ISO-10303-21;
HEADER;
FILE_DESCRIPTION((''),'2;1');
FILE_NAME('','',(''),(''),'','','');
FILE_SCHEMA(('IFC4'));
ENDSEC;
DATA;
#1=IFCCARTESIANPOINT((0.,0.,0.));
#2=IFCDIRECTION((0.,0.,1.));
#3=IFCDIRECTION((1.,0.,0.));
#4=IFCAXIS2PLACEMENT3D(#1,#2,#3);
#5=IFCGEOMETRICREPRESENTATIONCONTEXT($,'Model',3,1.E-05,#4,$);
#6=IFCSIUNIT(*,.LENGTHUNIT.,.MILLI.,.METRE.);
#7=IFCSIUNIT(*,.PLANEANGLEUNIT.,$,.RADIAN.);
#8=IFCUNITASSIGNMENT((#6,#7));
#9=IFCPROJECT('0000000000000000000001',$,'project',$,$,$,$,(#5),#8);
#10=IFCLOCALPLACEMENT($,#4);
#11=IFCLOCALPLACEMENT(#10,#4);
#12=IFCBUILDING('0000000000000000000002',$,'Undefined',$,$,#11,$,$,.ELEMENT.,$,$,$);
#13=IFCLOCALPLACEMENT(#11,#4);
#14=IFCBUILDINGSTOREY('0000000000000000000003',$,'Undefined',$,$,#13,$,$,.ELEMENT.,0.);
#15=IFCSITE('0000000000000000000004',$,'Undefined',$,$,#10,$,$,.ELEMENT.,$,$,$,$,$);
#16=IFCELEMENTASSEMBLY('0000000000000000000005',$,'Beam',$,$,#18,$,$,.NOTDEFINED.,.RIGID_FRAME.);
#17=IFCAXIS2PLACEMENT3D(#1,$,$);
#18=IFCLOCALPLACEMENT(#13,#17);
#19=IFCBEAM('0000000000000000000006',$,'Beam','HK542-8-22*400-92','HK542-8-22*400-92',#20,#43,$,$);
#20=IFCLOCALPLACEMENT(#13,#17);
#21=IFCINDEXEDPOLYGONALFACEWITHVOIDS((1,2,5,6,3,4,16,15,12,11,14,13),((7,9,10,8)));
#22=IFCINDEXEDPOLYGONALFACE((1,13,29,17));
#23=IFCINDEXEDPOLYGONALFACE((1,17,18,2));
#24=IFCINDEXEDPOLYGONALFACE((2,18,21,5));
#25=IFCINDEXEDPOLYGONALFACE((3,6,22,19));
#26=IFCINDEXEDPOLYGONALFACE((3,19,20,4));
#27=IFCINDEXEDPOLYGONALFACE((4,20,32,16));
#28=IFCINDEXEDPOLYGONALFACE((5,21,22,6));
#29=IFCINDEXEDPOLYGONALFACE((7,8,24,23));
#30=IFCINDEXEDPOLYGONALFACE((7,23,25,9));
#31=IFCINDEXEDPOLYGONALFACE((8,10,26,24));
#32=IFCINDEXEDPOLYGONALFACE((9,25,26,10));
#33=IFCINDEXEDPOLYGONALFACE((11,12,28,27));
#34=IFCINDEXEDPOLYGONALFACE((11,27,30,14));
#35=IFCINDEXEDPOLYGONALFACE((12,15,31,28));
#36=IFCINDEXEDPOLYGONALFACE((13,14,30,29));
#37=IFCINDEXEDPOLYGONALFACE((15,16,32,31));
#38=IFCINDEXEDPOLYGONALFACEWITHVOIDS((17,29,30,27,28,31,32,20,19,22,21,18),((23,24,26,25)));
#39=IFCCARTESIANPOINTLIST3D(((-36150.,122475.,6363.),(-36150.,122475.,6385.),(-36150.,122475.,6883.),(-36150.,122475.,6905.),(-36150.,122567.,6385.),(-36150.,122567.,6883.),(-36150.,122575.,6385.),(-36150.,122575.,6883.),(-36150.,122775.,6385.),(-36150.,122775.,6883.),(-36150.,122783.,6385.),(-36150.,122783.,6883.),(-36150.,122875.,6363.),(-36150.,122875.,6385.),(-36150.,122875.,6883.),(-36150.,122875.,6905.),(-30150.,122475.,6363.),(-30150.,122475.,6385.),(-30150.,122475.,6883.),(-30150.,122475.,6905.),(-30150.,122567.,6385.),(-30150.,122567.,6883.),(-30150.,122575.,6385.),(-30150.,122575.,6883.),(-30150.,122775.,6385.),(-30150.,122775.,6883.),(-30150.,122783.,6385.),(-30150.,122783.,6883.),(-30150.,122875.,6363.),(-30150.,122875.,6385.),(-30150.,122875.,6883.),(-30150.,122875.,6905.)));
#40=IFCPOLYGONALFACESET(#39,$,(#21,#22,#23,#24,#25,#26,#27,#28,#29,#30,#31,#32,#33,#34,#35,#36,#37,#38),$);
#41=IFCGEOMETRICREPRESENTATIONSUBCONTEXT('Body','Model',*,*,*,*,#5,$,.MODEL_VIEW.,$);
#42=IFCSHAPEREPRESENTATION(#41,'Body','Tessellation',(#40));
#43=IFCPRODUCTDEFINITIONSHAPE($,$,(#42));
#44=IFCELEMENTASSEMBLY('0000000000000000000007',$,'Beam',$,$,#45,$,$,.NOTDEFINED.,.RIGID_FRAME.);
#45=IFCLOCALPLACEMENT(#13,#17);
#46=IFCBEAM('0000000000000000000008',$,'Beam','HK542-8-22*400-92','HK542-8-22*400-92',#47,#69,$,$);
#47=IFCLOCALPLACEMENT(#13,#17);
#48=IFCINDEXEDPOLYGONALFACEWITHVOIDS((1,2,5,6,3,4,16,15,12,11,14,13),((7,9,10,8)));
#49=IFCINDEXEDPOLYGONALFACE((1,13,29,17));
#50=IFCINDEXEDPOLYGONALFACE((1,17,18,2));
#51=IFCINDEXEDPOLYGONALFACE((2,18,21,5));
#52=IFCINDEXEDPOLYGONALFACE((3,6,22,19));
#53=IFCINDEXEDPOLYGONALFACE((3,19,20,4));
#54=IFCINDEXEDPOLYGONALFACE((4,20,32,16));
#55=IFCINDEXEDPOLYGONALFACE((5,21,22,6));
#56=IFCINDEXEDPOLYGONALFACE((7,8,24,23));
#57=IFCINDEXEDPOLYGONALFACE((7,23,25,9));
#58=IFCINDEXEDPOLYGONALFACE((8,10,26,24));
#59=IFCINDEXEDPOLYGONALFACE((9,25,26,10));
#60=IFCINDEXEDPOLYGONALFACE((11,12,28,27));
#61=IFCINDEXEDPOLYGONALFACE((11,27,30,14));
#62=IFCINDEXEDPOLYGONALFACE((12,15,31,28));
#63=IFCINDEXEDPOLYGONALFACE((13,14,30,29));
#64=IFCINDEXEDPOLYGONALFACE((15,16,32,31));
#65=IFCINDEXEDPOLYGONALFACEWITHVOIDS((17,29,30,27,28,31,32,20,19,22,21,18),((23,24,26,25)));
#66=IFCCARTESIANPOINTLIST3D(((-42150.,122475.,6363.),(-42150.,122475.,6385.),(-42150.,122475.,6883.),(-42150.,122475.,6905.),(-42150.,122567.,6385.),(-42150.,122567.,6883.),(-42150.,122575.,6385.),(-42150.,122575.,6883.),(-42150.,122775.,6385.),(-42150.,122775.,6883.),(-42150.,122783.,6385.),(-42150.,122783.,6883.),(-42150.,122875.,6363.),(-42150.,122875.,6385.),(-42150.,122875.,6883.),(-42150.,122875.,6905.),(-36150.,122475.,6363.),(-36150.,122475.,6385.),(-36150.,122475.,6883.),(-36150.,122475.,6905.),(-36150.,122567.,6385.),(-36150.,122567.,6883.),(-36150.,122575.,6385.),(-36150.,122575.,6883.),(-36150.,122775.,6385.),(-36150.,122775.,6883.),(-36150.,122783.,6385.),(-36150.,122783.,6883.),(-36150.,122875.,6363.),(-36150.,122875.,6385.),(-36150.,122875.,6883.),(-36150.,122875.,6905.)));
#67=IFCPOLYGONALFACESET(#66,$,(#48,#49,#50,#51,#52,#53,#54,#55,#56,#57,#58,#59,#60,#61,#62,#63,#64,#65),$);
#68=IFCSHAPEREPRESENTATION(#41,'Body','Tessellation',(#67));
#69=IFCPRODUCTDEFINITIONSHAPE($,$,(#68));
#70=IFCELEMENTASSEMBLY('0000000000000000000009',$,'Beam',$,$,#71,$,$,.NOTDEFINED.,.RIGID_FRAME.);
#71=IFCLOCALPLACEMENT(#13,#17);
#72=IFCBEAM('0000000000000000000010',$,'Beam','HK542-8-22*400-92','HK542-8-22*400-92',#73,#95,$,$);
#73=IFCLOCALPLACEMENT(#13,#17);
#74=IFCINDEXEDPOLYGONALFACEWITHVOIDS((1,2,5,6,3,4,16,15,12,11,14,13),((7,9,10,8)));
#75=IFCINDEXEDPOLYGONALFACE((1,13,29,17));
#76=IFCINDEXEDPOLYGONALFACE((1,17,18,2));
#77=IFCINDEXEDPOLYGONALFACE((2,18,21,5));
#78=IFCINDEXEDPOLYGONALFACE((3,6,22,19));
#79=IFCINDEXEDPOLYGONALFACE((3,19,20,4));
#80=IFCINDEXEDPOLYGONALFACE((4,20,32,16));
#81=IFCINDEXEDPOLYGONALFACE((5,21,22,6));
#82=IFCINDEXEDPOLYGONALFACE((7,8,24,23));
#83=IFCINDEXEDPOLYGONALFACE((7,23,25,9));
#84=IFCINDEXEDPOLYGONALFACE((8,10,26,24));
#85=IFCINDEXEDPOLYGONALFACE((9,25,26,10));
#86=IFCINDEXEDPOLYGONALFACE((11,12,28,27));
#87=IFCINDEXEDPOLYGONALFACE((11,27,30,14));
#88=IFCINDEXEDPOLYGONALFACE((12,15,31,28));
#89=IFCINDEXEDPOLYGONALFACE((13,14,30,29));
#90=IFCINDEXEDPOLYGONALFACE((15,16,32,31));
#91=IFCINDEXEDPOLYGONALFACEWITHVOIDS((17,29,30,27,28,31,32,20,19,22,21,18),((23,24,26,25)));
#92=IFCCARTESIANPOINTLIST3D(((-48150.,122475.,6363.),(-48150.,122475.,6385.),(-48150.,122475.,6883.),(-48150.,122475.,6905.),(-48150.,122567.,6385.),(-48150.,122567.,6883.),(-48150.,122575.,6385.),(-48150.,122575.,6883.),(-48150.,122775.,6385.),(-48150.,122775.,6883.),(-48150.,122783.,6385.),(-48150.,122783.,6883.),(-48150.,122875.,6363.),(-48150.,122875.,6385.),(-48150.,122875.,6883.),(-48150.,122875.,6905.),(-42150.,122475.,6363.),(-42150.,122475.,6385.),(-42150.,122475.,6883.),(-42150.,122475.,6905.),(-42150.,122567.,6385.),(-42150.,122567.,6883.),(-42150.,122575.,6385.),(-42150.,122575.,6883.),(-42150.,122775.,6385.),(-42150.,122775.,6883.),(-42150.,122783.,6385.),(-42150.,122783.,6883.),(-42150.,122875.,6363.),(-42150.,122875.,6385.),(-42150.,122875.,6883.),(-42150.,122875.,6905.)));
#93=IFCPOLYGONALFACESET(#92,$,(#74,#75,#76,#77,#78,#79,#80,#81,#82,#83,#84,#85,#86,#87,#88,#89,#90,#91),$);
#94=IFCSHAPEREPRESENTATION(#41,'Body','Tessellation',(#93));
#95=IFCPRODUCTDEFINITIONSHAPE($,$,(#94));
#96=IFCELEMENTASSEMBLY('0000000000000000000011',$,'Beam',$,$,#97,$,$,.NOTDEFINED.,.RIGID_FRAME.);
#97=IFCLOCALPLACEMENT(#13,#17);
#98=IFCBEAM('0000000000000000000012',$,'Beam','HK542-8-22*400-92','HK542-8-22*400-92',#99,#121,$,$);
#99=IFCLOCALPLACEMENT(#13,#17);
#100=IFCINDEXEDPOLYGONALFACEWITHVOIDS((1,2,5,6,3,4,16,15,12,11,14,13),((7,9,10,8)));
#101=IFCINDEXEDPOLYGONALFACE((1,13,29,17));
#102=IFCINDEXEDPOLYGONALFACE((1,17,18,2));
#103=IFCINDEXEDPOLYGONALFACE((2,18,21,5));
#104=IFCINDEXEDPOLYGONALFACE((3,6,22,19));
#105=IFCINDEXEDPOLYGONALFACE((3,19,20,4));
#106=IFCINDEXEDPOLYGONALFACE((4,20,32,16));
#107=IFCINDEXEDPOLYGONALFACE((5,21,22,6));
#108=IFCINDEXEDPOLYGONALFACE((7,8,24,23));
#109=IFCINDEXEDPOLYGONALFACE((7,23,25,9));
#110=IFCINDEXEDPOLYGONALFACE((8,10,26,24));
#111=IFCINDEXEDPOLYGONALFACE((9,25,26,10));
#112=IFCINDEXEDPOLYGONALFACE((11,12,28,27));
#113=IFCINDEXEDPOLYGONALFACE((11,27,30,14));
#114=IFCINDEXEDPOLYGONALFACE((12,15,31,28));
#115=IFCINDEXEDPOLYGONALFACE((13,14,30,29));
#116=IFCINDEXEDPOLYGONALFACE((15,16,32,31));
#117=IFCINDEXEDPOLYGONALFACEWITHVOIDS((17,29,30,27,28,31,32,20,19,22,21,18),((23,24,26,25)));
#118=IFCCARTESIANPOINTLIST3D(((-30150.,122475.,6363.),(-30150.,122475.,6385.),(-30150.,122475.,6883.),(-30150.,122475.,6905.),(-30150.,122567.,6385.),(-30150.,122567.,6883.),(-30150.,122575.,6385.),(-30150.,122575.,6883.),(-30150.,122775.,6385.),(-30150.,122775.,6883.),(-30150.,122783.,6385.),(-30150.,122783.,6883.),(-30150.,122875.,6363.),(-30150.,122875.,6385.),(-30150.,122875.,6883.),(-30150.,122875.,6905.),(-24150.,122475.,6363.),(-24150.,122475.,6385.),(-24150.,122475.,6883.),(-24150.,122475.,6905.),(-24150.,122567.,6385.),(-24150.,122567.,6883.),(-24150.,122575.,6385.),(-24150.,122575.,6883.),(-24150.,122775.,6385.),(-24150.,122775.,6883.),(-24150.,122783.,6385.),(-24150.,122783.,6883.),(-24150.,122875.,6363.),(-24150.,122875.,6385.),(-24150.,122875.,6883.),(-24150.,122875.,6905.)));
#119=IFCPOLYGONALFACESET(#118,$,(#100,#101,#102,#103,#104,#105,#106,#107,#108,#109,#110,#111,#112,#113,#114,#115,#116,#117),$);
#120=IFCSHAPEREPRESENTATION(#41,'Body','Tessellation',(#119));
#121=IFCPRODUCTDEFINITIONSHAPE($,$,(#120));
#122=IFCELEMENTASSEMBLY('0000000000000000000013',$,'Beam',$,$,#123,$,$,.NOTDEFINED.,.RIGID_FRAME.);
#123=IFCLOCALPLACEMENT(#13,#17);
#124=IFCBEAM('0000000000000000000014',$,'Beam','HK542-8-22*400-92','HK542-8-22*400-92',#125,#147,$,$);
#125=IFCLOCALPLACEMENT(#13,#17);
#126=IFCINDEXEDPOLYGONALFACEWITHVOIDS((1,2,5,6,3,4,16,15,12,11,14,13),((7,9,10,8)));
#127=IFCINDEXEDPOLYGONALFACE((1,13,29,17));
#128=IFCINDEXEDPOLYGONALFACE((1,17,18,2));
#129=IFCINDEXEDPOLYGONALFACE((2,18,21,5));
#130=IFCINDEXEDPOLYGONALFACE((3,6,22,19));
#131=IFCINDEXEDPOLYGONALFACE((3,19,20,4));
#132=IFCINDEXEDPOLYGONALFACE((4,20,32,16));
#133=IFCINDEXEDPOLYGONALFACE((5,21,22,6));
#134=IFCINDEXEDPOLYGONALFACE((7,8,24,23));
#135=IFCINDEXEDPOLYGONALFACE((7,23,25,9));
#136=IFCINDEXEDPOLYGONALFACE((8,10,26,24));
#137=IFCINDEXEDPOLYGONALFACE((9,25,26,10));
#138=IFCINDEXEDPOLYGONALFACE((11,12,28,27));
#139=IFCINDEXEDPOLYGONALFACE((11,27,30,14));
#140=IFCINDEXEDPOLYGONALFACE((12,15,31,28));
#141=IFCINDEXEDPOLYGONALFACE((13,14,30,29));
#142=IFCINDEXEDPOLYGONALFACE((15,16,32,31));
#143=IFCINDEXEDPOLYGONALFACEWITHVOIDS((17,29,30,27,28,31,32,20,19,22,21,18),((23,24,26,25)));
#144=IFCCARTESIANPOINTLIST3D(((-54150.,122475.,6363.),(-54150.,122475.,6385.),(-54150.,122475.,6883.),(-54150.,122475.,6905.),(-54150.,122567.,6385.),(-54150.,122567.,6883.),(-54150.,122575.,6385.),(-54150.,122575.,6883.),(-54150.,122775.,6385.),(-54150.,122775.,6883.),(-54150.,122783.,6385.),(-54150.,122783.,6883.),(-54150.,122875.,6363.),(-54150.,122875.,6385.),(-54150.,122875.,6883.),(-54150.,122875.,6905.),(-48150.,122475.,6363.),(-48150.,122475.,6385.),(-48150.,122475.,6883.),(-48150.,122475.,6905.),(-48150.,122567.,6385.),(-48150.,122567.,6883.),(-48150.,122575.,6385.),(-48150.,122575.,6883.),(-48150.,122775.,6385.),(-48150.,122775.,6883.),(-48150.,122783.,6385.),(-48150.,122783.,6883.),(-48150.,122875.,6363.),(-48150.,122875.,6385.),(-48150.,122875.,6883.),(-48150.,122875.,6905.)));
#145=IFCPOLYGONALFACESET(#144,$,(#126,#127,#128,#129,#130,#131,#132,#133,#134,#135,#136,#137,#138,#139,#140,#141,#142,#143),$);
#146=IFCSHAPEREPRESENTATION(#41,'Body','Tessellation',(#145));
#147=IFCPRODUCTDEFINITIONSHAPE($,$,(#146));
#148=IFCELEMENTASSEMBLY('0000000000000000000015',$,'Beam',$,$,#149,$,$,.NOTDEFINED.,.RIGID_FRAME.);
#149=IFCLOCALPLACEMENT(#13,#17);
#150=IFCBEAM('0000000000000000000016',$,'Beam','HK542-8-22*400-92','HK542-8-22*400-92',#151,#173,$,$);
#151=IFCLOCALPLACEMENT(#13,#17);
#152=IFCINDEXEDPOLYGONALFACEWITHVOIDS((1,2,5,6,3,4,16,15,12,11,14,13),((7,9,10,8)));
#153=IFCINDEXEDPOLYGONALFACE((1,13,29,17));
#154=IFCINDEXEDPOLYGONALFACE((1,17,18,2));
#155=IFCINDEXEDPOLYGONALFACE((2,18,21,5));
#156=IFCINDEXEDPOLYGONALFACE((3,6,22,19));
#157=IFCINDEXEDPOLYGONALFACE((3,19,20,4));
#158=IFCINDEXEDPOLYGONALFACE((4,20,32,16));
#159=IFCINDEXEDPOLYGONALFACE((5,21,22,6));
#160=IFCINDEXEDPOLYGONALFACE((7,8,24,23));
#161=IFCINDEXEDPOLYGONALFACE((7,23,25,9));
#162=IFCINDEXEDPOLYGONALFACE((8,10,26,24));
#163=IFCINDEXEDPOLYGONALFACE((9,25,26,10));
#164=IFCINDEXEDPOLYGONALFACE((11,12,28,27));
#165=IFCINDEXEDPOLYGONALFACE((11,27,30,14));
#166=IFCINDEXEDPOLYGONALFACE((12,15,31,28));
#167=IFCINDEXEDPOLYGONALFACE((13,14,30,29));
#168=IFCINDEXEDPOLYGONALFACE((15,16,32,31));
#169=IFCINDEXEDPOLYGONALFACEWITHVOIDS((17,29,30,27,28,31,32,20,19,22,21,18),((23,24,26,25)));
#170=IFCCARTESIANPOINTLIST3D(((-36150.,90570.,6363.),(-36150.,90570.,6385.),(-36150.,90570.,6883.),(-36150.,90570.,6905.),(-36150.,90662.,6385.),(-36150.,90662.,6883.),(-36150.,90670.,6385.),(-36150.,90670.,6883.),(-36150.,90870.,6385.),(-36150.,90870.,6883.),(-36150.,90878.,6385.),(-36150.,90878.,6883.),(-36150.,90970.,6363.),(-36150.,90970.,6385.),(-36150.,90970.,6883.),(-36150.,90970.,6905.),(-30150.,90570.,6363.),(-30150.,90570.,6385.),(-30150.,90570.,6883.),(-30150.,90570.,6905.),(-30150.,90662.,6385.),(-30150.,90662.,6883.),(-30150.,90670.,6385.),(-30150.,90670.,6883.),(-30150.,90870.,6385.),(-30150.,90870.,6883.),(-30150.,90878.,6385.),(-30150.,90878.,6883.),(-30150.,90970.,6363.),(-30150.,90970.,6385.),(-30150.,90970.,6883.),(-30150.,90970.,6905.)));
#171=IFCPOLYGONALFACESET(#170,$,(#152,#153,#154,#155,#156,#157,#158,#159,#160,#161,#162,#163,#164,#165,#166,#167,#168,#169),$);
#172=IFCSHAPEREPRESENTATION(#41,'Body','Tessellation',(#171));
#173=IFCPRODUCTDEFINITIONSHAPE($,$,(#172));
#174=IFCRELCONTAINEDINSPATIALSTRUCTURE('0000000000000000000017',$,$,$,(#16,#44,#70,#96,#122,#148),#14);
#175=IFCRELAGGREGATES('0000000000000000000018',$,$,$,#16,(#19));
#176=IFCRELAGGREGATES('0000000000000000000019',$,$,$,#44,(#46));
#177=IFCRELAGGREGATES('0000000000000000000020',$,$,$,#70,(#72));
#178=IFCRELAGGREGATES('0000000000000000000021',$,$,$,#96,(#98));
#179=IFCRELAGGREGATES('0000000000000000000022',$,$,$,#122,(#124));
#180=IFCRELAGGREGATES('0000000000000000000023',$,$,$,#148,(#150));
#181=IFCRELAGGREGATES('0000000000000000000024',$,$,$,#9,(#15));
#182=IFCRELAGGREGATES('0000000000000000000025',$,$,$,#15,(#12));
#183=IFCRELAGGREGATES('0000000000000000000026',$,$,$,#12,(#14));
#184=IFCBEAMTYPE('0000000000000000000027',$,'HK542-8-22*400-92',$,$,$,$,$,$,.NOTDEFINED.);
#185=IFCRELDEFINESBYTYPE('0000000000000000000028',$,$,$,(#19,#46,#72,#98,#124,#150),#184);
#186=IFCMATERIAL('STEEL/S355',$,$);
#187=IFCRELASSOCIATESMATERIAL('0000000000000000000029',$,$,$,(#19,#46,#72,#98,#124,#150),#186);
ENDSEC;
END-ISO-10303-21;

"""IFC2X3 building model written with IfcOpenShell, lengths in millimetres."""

from ifc_helpers import new_model, si_unit, frame, origin_with_axes, place, context, subcontext, project, spatial, polyline, outline, extrude, material, type_object, element, aggregate, save


model = new_model("IFC2X3")

# Units and contexts
model_context = context("Model", 3, precision=1e-05, world=origin_with_axes())
body_context = subcontext(model_context, "Body", "Model", "MODEL_VIEW")
ifc_project = project(units=[si_unit("LENGTHUNIT", "METRE", prefix="MILLI"), si_unit("PLANEANGLEUNIT", "RADIAN")], contexts=[model_context])

# Site, building, storey
site_placement = place(None, origin_with_axes())
site = spatial("IfcSite", under=ifc_project, at=site_placement, Name="Undefined", CompositionType="ELEMENT")
building_placement = place(site_placement, origin_with_axes())
building = spatial("IfcBuilding", under=site, at=building_placement, Name="Undefined", CompositionType="ELEMENT")
storey_placement = place(building_placement, origin_with_axes())
storey = spatial("IfcBuildingStorey", under=building, at=storey_placement, Name="Undefined", CompositionType="ELEMENT", Elevation=0.0)

# Element assemblies, beams
assembly_1_placement = place(storey_placement, origin_with_axes())
assembly_1 = element("IfcElementAssembly", 1, at=assembly_1_placement, inside=storey, Name="Beam", AssemblyPlace="NOTDEFINED", PredefinedType="RIGID_FRAME")
ifc_material_1 = material(Name="STEEL/S355")
beam_type_1 = type_object("IfcBeamType", Name="HK542-8-22*400-92", PredefinedType="NOTDEFINED")
beam_1_placement = place(assembly_1_placement, frame((-30150.0, 122675.0, 6634.0), z_axis=(0.0, 0.0, 1.0), x_axis=(-1.0, 0.0, 0.0)))
beam_1 = element("IfcBeam", 2, at=beam_1_placement, type_object=beam_type_1, material=ifc_material_1, Name="Beam", Description="HK542-8-22*400-92", ObjectType="HK542-8-22*400-92", context=body_context, shape_type="SweptSolid", body=[
    extrude(outline(polyline([(-200.0, 249.0), (-200.0, 271.0), (200.0, 271.0), (200.0, 249.0), (108.0, 249.0), (108.0, -249.0), (200.0, -249.0), (200.0, -271.0), (-200.0, -271.0), (-200.0, -249.0), (-108.0, -249.0), (-108.0, 249.0), (-200.0, 249.0)]), holes=[polyline([(-100.0, -249.0), (100.0, -249.0), (100.0, 249.0), (-100.0, 249.0), (-100.0, -249.0)])]), frame((6000.0, 0.0, 0.0), z_axis=(-1.0, 0.0, 0.0), x_axis=(0.0, -1.0, 0.0)), (0.0, 0.0, 1.0), 6000.0),
])
aggregate(assembly_1, [beam_1])
assembly_2_placement = place(storey_placement, origin_with_axes())
assembly_2 = element("IfcElementAssembly", 3, at=assembly_2_placement, inside=storey, Name="Beam", AssemblyPlace="NOTDEFINED", PredefinedType="RIGID_FRAME")
beam_2_placement = place(assembly_2_placement, frame((-36150.0, 122675.0, 6634.0), z_axis=(0.0, 0.0, 1.0), x_axis=(-1.0, 0.0, 0.0)))
beam_2 = element("IfcBeam", 4, at=beam_2_placement, type_object=beam_type_1, material=ifc_material_1, Name="Beam", Description="HK542-8-22*400-92", ObjectType="HK542-8-22*400-92", context=body_context, shape_type="SweptSolid", body=[
    extrude(outline(polyline([(-200.0, 249.0), (-200.0, 271.0), (200.0, 271.0), (200.0, 249.0), (108.0, 249.0), (108.0, -249.0), (200.0, -249.0), (200.0, -271.0), (-200.0, -271.0), (-200.0, -249.0), (-108.0, -249.0), (-108.0, 249.0), (-200.0, 249.0)]), holes=[polyline([(-100.0, -249.0), (100.0, -249.0), (100.0, 249.0), (-100.0, 249.0), (-100.0, -249.0)])]), frame((6000.0, 0.0, 0.0), z_axis=(-1.0, 0.0, 0.0), x_axis=(0.0, -1.0, 0.0)), (0.0, 0.0, 1.0), 6000.0),
])
aggregate(assembly_2, [beam_2])
assembly_3_placement = place(storey_placement, origin_with_axes())
assembly_3 = element("IfcElementAssembly", 5, at=assembly_3_placement, inside=storey, Name="Beam", AssemblyPlace="NOTDEFINED", PredefinedType="RIGID_FRAME")
beam_3_placement = place(assembly_3_placement, frame((-42150.0, 122675.0, 6634.0), z_axis=(0.0, 0.0, 1.0), x_axis=(-1.0, 0.0, 0.0)))
beam_3 = element("IfcBeam", 6, at=beam_3_placement, type_object=beam_type_1, material=ifc_material_1, Name="Beam", Description="HK542-8-22*400-92", ObjectType="HK542-8-22*400-92", context=body_context, shape_type="SweptSolid", body=[
    extrude(outline(polyline([(-200.0, 249.0), (-200.0, 271.0), (200.0, 271.0), (200.0, 249.0), (108.0, 249.0), (108.0, -249.0), (200.0, -249.0), (200.0, -271.0), (-200.0, -271.0), (-200.0, -249.0), (-108.0, -249.0), (-108.0, 249.0), (-200.0, 249.0)]), holes=[polyline([(-100.0, -249.0), (100.0, -249.0), (100.0, 249.0), (-100.0, 249.0), (-100.0, -249.0)])]), frame((6000.0, 0.0, 0.0), z_axis=(-1.0, 0.0, 0.0), x_axis=(0.0, -1.0, 0.0)), (0.0, 0.0, 1.0), 6000.0),
])
aggregate(assembly_3, [beam_3])
assembly_4_placement = place(storey_placement, origin_with_axes())
assembly_4 = element("IfcElementAssembly", 7, at=assembly_4_placement, inside=storey, Name="Beam", AssemblyPlace="NOTDEFINED", PredefinedType="RIGID_FRAME")
beam_4_placement = place(assembly_4_placement, frame((-24150.0, 122675.0, 6634.0), z_axis=(0.0, 0.0, 1.0), x_axis=(-1.0, 0.0, 0.0)))
beam_4 = element("IfcBeam", 8, at=beam_4_placement, type_object=beam_type_1, material=ifc_material_1, Name="Beam", Description="HK542-8-22*400-92", ObjectType="HK542-8-22*400-92", context=body_context, shape_type="SweptSolid", body=[
    extrude(outline(polyline([(-200.0, 249.0), (-200.0, 271.0), (200.0, 271.0), (200.0, 249.0), (108.0, 249.0), (108.0, -249.0), (200.0, -249.0), (200.0, -271.0), (-200.0, -271.0), (-200.0, -249.0), (-108.0, -249.0), (-108.0, 249.0), (-200.0, 249.0)]), holes=[polyline([(-100.0, -249.0), (100.0, -249.0), (100.0, 249.0), (-100.0, 249.0), (-100.0, -249.0)])]), frame((6000.0, 0.0, 0.0), z_axis=(-1.0, 0.0, 0.0), x_axis=(0.0, -1.0, 0.0)), (0.0, 0.0, 1.0), 6000.0),
])
aggregate(assembly_4, [beam_4])
assembly_5_placement = place(storey_placement, origin_with_axes())
assembly_5 = element("IfcElementAssembly", 9, at=assembly_5_placement, inside=storey, Name="Beam", AssemblyPlace="NOTDEFINED", PredefinedType="RIGID_FRAME")
beam_5_placement = place(assembly_5_placement, frame((-48150.0, 122675.0, 6634.0), z_axis=(0.0, 0.0, 1.0), x_axis=(-1.0, 0.0, 0.0)))
beam_5 = element("IfcBeam", 10, at=beam_5_placement, type_object=beam_type_1, material=ifc_material_1, Name="Beam", Description="HK542-8-22*400-92", ObjectType="HK542-8-22*400-92", context=body_context, shape_type="SweptSolid", body=[
    extrude(outline(polyline([(-200.0, 249.0), (-200.0, 271.0), (200.0, 271.0), (200.0, 249.0), (108.0, 249.0), (108.0, -249.0), (200.0, -249.0), (200.0, -271.0), (-200.0, -271.0), (-200.0, -249.0), (-108.0, -249.0), (-108.0, 249.0), (-200.0, 249.0)]), holes=[polyline([(-100.0, -249.0), (100.0, -249.0), (100.0, 249.0), (-100.0, 249.0), (-100.0, -249.0)])]), frame((6000.0, 0.0, 0.0), z_axis=(-1.0, 0.0, 0.0), x_axis=(0.0, -1.0, 0.0)), (0.0, 0.0, 1.0), 6000.0),
])
aggregate(assembly_5, [beam_5])
assembly_6_placement = place(storey_placement, origin_with_axes())
assembly_6 = element("IfcElementAssembly", 11, at=assembly_6_placement, inside=storey, Name="Beam", AssemblyPlace="NOTDEFINED", PredefinedType="RIGID_FRAME")
beam_6_placement = place(assembly_6_placement, frame((-30150.0, 90770.0, 6634.0), z_axis=(0.0, 0.0, 1.0), x_axis=(-1.0, 0.0, 0.0)))
beam_6 = element("IfcBeam", 12, at=beam_6_placement, type_object=beam_type_1, material=ifc_material_1, Name="Beam", Description="HK542-8-22*400-92", ObjectType="HK542-8-22*400-92", context=body_context, shape_type="SweptSolid", body=[
    extrude(outline(polyline([(-200.0, 249.0), (-200.0, 271.0), (200.0, 271.0), (200.0, 249.0), (108.0, 249.0), (108.0, -249.0), (200.0, -249.0), (200.0, -271.0), (-200.0, -271.0), (-200.0, -249.0), (-108.0, -249.0), (-108.0, 249.0), (-200.0, 249.0)]), holes=[polyline([(-100.0, -249.0), (100.0, -249.0), (100.0, 249.0), (-100.0, 249.0), (-100.0, -249.0)])]), frame((6000.0, 0.0, 0.0), z_axis=(-1.0, 0.0, 0.0), x_axis=(0.0, -1.0, 0.0)), (0.0, 0.0, 1.0), 6000.0),
])
aggregate(assembly_6, [beam_6])

save(model, "model.ifc")
